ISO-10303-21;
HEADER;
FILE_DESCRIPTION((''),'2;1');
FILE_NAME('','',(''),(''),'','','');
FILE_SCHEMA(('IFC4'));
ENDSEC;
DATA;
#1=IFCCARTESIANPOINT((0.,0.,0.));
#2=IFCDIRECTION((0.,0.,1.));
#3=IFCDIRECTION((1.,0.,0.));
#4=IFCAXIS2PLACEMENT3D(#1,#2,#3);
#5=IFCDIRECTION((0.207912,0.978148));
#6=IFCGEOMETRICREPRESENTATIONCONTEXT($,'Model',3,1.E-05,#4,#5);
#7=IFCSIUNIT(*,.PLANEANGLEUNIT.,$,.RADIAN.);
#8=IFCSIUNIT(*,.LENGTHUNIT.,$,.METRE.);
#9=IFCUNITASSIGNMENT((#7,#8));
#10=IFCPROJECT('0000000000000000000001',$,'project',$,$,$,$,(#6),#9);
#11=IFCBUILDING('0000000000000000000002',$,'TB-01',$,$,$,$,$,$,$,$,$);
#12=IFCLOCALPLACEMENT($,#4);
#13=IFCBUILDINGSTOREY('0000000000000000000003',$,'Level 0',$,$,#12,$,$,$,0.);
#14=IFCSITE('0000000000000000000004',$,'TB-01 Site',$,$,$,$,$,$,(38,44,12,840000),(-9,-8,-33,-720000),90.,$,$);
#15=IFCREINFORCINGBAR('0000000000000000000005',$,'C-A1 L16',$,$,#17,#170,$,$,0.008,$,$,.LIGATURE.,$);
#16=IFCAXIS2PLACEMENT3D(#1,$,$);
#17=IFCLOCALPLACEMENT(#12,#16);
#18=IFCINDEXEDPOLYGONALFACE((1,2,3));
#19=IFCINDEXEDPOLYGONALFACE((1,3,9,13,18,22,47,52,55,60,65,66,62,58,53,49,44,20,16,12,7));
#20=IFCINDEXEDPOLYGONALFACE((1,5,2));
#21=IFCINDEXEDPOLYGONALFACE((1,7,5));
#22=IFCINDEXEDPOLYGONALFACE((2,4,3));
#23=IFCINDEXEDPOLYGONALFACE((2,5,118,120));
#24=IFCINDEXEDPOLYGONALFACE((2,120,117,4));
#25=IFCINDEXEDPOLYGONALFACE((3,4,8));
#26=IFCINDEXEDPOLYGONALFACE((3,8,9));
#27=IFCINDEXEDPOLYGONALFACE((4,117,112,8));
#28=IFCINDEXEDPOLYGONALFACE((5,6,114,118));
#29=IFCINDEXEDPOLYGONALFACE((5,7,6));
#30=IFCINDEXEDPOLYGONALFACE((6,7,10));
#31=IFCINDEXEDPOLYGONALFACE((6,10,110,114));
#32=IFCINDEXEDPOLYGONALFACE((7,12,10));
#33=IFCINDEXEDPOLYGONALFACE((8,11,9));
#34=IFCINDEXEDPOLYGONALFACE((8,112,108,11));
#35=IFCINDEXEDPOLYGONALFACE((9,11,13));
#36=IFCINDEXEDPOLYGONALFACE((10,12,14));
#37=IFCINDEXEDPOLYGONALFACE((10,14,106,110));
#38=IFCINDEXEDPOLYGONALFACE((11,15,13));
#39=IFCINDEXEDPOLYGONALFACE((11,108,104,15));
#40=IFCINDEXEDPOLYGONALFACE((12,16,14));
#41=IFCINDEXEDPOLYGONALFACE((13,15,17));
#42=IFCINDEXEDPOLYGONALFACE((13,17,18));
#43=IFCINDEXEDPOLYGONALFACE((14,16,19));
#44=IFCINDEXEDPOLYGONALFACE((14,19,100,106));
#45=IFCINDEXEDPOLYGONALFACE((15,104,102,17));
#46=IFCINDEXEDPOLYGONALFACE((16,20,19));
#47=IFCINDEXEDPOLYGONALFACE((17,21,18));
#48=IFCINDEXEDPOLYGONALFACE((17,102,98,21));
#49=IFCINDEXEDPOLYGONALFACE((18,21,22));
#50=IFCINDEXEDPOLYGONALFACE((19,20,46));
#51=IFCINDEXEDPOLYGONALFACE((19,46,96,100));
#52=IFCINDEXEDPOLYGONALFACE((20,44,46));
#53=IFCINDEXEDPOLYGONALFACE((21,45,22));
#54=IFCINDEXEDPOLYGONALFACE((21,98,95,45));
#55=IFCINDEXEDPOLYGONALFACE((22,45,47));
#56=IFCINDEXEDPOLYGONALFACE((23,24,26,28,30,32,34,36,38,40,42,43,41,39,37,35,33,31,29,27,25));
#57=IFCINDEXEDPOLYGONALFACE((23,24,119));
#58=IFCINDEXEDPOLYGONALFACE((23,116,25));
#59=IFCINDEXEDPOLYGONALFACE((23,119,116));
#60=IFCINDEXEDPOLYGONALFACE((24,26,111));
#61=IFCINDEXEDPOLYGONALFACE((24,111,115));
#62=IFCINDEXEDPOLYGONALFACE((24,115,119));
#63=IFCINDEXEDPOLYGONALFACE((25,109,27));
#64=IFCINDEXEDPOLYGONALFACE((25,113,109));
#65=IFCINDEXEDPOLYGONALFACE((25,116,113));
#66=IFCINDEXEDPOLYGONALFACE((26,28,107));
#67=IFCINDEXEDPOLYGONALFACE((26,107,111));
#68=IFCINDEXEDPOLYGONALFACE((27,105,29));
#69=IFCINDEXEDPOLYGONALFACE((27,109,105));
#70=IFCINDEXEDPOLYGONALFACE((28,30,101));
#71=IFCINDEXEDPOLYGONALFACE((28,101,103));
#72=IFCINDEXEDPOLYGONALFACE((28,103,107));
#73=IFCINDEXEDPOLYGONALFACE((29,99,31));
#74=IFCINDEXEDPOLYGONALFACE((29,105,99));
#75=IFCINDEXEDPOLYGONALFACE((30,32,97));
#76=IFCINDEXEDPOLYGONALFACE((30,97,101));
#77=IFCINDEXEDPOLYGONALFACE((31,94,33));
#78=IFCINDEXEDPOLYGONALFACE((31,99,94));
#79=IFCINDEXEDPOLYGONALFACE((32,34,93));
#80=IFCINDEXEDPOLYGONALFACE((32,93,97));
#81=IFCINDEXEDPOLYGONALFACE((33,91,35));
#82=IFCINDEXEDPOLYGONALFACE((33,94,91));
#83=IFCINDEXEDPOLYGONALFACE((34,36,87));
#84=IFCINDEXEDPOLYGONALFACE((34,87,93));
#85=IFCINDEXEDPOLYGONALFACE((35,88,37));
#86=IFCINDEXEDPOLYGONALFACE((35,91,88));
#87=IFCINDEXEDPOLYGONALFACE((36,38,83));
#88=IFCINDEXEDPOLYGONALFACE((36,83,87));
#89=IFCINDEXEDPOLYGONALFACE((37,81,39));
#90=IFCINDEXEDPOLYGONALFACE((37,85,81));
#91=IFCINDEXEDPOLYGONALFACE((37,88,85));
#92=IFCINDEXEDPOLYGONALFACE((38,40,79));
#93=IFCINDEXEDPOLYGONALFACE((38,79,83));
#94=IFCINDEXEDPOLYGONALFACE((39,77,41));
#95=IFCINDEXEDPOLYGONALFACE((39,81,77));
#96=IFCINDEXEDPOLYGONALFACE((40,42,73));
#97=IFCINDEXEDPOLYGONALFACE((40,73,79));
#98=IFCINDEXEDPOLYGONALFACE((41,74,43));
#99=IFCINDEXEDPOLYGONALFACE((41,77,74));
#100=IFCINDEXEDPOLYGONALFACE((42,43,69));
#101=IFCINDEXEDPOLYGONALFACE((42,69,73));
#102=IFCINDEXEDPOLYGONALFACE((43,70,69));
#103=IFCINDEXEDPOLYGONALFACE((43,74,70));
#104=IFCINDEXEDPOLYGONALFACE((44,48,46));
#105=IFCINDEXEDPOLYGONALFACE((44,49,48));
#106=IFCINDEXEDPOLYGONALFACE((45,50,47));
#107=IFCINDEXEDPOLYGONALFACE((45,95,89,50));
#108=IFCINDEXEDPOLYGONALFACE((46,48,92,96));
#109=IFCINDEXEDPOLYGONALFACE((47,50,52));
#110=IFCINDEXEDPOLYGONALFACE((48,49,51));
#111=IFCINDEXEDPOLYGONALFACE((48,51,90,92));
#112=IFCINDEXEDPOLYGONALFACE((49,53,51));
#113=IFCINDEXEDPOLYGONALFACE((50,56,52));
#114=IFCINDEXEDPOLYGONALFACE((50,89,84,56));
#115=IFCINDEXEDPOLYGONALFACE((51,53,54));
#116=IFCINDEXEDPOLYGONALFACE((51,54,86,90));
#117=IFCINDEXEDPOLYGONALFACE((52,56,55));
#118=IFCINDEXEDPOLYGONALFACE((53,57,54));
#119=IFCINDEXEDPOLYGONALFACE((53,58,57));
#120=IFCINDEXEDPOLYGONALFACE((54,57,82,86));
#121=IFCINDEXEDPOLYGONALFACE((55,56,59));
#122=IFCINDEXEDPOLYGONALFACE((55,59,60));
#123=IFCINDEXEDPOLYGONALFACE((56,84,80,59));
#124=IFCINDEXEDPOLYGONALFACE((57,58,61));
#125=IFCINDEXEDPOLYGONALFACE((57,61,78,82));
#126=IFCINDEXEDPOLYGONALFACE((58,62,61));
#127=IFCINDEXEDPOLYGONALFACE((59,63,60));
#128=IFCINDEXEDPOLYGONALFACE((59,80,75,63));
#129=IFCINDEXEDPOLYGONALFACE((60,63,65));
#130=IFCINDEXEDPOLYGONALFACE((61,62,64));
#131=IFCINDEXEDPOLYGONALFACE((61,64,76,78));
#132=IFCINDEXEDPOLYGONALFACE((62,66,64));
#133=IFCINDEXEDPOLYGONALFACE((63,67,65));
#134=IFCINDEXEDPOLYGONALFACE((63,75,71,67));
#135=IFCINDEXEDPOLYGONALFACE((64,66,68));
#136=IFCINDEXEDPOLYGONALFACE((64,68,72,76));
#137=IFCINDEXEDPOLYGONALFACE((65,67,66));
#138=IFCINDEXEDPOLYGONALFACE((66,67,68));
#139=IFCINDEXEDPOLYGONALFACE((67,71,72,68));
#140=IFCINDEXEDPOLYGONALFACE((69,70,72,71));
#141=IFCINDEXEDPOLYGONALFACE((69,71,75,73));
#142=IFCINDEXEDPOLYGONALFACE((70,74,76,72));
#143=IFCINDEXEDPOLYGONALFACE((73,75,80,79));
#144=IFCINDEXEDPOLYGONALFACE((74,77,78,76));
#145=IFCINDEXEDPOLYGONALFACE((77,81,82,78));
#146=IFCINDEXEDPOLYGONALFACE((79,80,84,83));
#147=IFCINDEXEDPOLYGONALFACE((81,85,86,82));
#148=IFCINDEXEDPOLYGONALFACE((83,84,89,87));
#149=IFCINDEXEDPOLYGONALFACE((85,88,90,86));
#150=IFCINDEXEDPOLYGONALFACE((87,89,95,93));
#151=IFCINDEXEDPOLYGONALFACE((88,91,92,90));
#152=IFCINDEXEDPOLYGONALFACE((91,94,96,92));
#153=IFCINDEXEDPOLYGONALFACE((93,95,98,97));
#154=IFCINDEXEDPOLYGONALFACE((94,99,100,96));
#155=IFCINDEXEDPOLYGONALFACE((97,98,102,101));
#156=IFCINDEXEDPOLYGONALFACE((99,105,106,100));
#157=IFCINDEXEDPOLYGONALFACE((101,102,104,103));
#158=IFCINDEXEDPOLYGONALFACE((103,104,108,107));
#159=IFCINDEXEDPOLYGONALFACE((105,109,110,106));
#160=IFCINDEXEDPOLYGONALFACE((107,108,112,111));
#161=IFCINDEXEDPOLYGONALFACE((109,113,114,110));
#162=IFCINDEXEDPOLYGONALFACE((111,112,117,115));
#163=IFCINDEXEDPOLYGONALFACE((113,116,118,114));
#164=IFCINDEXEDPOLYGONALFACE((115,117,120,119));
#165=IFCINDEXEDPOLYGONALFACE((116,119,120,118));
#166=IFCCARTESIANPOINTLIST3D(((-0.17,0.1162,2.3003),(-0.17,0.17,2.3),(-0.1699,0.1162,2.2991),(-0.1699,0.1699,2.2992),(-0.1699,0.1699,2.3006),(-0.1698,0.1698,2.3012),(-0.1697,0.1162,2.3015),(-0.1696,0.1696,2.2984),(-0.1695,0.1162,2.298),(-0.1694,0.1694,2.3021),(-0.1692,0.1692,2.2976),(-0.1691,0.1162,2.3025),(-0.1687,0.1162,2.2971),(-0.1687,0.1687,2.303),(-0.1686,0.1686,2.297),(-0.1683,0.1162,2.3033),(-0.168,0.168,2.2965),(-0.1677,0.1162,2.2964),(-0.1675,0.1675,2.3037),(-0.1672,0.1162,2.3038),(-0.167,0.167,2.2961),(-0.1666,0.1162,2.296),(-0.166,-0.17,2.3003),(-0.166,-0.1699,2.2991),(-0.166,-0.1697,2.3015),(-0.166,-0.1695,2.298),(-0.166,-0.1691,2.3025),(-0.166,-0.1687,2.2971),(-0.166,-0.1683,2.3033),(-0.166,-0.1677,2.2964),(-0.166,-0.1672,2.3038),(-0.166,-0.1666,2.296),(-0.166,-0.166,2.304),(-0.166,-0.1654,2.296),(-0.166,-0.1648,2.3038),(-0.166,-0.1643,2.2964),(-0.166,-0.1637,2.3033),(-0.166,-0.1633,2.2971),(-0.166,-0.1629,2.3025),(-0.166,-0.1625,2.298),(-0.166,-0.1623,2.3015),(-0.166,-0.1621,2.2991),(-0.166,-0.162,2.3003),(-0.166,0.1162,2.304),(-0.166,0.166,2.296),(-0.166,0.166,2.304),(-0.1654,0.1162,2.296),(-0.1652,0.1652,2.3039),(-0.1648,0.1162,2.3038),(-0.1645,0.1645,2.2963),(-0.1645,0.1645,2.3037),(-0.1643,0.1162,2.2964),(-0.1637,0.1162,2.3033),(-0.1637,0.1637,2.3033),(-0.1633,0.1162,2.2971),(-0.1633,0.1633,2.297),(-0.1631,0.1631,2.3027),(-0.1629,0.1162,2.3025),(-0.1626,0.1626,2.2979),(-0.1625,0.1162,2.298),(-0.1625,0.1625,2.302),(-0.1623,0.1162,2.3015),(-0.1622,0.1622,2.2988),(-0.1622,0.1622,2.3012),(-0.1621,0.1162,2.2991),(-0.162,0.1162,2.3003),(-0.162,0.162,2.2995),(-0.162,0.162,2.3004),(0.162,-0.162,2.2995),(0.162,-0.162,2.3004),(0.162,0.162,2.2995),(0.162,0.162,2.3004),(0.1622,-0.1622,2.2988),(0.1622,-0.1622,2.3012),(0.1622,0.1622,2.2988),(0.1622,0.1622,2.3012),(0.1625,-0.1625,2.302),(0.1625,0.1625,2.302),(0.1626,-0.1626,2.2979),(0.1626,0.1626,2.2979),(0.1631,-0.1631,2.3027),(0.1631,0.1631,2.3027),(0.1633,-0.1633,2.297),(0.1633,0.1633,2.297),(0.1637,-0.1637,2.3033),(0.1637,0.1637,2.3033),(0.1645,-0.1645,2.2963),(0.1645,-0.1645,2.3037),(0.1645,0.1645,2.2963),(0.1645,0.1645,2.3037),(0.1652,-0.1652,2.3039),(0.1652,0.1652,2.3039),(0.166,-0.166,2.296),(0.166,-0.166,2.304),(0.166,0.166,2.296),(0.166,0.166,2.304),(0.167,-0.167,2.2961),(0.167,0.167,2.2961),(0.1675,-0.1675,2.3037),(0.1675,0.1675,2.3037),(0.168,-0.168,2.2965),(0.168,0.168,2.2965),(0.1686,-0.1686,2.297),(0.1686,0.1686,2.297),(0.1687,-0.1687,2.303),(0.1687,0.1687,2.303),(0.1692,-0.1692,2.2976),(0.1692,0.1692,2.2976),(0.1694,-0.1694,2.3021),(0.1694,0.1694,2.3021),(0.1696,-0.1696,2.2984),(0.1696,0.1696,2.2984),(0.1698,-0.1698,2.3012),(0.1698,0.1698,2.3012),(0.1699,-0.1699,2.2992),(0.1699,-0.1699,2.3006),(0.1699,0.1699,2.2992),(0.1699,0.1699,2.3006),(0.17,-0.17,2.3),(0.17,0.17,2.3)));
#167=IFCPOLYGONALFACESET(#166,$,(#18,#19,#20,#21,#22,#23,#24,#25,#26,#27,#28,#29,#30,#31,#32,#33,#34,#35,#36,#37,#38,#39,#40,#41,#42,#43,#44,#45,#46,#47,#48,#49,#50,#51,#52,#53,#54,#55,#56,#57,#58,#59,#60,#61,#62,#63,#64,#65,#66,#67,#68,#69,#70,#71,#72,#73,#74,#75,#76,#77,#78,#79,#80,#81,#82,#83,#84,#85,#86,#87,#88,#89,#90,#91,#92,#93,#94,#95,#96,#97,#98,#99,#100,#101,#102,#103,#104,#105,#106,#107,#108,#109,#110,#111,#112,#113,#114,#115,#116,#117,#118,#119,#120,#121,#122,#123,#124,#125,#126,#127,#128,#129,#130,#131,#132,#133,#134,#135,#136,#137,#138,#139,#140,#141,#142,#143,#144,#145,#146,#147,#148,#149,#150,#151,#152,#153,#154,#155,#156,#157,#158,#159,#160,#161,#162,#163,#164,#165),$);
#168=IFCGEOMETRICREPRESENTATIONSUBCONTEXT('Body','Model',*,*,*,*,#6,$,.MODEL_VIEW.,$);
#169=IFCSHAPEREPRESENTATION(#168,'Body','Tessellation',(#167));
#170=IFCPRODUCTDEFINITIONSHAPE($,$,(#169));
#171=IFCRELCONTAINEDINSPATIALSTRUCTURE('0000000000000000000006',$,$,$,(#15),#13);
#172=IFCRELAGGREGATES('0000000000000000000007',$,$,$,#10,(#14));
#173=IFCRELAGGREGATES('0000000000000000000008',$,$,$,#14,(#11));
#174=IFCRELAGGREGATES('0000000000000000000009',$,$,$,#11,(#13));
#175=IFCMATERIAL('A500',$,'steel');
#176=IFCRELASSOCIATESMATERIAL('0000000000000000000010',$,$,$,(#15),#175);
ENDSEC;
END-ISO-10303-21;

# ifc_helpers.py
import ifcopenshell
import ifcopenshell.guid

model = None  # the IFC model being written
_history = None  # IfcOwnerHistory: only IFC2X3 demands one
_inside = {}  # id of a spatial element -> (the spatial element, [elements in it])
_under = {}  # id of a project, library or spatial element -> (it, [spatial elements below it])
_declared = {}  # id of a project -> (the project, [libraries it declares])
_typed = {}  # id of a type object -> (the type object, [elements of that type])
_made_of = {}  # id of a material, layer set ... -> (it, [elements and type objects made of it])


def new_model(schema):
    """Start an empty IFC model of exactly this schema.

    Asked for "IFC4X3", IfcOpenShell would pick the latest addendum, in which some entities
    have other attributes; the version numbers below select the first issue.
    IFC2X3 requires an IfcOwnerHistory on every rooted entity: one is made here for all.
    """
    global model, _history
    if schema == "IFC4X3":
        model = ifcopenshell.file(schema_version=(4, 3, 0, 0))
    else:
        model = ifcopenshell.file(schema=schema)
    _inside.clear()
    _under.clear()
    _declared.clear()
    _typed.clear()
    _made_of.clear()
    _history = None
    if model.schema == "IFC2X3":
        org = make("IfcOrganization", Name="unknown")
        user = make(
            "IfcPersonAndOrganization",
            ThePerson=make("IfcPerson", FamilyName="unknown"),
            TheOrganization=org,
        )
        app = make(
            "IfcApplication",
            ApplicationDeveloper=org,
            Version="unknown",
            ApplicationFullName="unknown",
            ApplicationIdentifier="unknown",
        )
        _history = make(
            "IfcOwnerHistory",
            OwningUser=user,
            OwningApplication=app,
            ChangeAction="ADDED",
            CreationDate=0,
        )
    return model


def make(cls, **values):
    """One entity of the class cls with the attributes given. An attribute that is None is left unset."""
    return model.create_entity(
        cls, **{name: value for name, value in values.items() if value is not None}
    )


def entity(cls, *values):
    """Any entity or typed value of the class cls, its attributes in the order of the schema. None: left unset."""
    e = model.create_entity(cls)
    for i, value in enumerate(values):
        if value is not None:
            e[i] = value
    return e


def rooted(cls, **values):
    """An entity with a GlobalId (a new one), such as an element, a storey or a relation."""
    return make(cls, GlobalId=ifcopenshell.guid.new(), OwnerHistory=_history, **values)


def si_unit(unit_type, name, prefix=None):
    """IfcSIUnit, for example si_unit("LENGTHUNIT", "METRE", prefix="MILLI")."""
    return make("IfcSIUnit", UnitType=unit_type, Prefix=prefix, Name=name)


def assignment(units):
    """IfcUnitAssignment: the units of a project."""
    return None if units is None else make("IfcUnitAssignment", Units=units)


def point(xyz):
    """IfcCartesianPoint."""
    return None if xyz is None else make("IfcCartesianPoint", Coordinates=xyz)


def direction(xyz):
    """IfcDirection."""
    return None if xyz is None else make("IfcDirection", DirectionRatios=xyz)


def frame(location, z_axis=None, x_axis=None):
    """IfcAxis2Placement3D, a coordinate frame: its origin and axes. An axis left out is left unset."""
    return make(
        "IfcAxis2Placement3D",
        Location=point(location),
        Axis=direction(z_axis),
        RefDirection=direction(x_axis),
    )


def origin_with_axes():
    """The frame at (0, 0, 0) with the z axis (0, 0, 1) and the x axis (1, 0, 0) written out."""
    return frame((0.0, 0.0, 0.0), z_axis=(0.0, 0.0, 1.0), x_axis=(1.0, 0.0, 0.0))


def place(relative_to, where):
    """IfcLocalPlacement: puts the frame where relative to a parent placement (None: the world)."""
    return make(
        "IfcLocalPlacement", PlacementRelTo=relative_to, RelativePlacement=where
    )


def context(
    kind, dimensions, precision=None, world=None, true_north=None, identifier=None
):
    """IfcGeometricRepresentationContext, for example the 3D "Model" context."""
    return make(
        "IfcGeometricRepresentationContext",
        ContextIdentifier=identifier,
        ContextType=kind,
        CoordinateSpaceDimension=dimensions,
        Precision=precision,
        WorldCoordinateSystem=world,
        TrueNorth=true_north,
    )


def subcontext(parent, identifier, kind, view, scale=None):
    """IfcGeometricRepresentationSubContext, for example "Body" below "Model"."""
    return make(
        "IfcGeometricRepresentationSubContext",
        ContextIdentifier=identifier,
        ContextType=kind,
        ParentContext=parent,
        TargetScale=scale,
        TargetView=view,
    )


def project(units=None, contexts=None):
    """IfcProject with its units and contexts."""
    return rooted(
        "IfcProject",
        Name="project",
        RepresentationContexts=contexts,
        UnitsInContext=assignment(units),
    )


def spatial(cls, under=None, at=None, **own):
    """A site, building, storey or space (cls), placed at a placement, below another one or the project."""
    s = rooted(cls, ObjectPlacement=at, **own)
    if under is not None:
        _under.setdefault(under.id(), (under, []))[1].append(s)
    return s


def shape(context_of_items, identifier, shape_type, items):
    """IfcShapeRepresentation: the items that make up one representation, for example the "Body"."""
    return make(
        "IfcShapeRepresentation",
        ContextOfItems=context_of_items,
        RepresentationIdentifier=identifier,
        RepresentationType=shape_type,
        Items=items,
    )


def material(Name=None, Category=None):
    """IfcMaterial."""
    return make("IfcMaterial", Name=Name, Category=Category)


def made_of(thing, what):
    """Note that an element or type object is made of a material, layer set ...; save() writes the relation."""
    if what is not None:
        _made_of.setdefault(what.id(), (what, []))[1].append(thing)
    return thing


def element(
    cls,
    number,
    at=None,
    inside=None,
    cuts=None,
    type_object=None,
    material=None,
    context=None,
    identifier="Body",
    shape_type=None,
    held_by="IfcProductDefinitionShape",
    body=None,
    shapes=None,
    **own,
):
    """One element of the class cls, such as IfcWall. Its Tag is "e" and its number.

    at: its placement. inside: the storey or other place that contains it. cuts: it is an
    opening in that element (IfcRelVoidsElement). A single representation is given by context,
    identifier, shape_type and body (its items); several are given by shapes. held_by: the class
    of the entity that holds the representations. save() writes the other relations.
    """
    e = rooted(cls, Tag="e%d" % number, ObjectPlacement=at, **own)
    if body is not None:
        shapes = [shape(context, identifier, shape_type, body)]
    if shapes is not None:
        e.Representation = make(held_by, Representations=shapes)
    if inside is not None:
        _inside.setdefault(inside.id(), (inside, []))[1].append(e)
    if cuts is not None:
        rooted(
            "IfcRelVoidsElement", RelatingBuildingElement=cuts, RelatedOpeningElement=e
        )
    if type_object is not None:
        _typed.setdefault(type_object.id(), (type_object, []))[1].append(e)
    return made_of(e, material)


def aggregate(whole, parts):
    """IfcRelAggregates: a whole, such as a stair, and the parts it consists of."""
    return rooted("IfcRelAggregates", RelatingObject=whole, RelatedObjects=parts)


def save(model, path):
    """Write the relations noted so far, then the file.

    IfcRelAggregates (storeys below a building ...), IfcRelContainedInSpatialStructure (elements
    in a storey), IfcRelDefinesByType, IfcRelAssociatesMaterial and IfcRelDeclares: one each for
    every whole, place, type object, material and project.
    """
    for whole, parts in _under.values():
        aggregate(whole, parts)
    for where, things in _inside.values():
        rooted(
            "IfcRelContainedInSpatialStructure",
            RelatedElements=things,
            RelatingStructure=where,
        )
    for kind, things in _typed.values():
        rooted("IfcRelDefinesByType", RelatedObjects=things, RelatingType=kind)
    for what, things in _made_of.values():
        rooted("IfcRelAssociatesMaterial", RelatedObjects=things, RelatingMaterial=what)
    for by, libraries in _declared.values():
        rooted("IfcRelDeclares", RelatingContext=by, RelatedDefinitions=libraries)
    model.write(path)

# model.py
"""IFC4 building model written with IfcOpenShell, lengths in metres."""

from ifc_helpers import new_model, entity, si_unit, direction, origin_with_axes, place, context, subcontext, project, spatial, material, element, save


model = new_model("IFC4")

# Units and contexts
model_context = context("Model", 3, precision=1e-05, world=origin_with_axes(), true_north=direction((0.207912, 0.978148)))
body_context = subcontext(model_context, "Body", "Model", "MODEL_VIEW")
ifc_project = project(units=[si_unit("PLANEANGLEUNIT", "RADIAN"), si_unit("LENGTHUNIT", "METRE")], contexts=[model_context])

# Site, building, storey
site = spatial("IfcSite", under=ifc_project, Name="TB-01 Site", RefLatitude=(38, 44, 12, 840000), RefLongitude=(-9, -8, -33, -720000), RefElevation=90.0)
building = spatial("IfcBuilding", under=site, Name="TB-01")
storey_placement = place(None, origin_with_axes())
storey = spatial("IfcBuildingStorey", under=building, at=storey_placement, Name="Level 0", Elevation=0.0)

# Reinforcing bar
ifc_material_1 = material(Name="A500", Category="steel")
reinforcing_bar_1_placement = place(storey_placement, origin_with_axes())
element("IfcReinforcingBar", 1, at=reinforcing_bar_1_placement, inside=storey, material=ifc_material_1, Name="C-A1 L16", NominalDiameter=0.008, PredefinedType="LIGATURE", context=body_context, shape_type="AdvancedSweptSolid", body=[
    entity("IfcSweptDiskSolid", entity("IfcPolyline", [entity("IfcCartesianPoint", [-0.166, -0.166, 2.3]), entity("IfcCartesianPoint", [0.166, -0.166, 2.3]), entity("IfcCartesianPoint", [0.166, 0.166, 2.3]), entity("IfcCartesianPoint", [-0.166, 0.166, 2.3]), entity("IfcCartesianPoint", [-0.166, 0.1162, 2.3])]), 0.004),
])

save(model, "model.ifc")
